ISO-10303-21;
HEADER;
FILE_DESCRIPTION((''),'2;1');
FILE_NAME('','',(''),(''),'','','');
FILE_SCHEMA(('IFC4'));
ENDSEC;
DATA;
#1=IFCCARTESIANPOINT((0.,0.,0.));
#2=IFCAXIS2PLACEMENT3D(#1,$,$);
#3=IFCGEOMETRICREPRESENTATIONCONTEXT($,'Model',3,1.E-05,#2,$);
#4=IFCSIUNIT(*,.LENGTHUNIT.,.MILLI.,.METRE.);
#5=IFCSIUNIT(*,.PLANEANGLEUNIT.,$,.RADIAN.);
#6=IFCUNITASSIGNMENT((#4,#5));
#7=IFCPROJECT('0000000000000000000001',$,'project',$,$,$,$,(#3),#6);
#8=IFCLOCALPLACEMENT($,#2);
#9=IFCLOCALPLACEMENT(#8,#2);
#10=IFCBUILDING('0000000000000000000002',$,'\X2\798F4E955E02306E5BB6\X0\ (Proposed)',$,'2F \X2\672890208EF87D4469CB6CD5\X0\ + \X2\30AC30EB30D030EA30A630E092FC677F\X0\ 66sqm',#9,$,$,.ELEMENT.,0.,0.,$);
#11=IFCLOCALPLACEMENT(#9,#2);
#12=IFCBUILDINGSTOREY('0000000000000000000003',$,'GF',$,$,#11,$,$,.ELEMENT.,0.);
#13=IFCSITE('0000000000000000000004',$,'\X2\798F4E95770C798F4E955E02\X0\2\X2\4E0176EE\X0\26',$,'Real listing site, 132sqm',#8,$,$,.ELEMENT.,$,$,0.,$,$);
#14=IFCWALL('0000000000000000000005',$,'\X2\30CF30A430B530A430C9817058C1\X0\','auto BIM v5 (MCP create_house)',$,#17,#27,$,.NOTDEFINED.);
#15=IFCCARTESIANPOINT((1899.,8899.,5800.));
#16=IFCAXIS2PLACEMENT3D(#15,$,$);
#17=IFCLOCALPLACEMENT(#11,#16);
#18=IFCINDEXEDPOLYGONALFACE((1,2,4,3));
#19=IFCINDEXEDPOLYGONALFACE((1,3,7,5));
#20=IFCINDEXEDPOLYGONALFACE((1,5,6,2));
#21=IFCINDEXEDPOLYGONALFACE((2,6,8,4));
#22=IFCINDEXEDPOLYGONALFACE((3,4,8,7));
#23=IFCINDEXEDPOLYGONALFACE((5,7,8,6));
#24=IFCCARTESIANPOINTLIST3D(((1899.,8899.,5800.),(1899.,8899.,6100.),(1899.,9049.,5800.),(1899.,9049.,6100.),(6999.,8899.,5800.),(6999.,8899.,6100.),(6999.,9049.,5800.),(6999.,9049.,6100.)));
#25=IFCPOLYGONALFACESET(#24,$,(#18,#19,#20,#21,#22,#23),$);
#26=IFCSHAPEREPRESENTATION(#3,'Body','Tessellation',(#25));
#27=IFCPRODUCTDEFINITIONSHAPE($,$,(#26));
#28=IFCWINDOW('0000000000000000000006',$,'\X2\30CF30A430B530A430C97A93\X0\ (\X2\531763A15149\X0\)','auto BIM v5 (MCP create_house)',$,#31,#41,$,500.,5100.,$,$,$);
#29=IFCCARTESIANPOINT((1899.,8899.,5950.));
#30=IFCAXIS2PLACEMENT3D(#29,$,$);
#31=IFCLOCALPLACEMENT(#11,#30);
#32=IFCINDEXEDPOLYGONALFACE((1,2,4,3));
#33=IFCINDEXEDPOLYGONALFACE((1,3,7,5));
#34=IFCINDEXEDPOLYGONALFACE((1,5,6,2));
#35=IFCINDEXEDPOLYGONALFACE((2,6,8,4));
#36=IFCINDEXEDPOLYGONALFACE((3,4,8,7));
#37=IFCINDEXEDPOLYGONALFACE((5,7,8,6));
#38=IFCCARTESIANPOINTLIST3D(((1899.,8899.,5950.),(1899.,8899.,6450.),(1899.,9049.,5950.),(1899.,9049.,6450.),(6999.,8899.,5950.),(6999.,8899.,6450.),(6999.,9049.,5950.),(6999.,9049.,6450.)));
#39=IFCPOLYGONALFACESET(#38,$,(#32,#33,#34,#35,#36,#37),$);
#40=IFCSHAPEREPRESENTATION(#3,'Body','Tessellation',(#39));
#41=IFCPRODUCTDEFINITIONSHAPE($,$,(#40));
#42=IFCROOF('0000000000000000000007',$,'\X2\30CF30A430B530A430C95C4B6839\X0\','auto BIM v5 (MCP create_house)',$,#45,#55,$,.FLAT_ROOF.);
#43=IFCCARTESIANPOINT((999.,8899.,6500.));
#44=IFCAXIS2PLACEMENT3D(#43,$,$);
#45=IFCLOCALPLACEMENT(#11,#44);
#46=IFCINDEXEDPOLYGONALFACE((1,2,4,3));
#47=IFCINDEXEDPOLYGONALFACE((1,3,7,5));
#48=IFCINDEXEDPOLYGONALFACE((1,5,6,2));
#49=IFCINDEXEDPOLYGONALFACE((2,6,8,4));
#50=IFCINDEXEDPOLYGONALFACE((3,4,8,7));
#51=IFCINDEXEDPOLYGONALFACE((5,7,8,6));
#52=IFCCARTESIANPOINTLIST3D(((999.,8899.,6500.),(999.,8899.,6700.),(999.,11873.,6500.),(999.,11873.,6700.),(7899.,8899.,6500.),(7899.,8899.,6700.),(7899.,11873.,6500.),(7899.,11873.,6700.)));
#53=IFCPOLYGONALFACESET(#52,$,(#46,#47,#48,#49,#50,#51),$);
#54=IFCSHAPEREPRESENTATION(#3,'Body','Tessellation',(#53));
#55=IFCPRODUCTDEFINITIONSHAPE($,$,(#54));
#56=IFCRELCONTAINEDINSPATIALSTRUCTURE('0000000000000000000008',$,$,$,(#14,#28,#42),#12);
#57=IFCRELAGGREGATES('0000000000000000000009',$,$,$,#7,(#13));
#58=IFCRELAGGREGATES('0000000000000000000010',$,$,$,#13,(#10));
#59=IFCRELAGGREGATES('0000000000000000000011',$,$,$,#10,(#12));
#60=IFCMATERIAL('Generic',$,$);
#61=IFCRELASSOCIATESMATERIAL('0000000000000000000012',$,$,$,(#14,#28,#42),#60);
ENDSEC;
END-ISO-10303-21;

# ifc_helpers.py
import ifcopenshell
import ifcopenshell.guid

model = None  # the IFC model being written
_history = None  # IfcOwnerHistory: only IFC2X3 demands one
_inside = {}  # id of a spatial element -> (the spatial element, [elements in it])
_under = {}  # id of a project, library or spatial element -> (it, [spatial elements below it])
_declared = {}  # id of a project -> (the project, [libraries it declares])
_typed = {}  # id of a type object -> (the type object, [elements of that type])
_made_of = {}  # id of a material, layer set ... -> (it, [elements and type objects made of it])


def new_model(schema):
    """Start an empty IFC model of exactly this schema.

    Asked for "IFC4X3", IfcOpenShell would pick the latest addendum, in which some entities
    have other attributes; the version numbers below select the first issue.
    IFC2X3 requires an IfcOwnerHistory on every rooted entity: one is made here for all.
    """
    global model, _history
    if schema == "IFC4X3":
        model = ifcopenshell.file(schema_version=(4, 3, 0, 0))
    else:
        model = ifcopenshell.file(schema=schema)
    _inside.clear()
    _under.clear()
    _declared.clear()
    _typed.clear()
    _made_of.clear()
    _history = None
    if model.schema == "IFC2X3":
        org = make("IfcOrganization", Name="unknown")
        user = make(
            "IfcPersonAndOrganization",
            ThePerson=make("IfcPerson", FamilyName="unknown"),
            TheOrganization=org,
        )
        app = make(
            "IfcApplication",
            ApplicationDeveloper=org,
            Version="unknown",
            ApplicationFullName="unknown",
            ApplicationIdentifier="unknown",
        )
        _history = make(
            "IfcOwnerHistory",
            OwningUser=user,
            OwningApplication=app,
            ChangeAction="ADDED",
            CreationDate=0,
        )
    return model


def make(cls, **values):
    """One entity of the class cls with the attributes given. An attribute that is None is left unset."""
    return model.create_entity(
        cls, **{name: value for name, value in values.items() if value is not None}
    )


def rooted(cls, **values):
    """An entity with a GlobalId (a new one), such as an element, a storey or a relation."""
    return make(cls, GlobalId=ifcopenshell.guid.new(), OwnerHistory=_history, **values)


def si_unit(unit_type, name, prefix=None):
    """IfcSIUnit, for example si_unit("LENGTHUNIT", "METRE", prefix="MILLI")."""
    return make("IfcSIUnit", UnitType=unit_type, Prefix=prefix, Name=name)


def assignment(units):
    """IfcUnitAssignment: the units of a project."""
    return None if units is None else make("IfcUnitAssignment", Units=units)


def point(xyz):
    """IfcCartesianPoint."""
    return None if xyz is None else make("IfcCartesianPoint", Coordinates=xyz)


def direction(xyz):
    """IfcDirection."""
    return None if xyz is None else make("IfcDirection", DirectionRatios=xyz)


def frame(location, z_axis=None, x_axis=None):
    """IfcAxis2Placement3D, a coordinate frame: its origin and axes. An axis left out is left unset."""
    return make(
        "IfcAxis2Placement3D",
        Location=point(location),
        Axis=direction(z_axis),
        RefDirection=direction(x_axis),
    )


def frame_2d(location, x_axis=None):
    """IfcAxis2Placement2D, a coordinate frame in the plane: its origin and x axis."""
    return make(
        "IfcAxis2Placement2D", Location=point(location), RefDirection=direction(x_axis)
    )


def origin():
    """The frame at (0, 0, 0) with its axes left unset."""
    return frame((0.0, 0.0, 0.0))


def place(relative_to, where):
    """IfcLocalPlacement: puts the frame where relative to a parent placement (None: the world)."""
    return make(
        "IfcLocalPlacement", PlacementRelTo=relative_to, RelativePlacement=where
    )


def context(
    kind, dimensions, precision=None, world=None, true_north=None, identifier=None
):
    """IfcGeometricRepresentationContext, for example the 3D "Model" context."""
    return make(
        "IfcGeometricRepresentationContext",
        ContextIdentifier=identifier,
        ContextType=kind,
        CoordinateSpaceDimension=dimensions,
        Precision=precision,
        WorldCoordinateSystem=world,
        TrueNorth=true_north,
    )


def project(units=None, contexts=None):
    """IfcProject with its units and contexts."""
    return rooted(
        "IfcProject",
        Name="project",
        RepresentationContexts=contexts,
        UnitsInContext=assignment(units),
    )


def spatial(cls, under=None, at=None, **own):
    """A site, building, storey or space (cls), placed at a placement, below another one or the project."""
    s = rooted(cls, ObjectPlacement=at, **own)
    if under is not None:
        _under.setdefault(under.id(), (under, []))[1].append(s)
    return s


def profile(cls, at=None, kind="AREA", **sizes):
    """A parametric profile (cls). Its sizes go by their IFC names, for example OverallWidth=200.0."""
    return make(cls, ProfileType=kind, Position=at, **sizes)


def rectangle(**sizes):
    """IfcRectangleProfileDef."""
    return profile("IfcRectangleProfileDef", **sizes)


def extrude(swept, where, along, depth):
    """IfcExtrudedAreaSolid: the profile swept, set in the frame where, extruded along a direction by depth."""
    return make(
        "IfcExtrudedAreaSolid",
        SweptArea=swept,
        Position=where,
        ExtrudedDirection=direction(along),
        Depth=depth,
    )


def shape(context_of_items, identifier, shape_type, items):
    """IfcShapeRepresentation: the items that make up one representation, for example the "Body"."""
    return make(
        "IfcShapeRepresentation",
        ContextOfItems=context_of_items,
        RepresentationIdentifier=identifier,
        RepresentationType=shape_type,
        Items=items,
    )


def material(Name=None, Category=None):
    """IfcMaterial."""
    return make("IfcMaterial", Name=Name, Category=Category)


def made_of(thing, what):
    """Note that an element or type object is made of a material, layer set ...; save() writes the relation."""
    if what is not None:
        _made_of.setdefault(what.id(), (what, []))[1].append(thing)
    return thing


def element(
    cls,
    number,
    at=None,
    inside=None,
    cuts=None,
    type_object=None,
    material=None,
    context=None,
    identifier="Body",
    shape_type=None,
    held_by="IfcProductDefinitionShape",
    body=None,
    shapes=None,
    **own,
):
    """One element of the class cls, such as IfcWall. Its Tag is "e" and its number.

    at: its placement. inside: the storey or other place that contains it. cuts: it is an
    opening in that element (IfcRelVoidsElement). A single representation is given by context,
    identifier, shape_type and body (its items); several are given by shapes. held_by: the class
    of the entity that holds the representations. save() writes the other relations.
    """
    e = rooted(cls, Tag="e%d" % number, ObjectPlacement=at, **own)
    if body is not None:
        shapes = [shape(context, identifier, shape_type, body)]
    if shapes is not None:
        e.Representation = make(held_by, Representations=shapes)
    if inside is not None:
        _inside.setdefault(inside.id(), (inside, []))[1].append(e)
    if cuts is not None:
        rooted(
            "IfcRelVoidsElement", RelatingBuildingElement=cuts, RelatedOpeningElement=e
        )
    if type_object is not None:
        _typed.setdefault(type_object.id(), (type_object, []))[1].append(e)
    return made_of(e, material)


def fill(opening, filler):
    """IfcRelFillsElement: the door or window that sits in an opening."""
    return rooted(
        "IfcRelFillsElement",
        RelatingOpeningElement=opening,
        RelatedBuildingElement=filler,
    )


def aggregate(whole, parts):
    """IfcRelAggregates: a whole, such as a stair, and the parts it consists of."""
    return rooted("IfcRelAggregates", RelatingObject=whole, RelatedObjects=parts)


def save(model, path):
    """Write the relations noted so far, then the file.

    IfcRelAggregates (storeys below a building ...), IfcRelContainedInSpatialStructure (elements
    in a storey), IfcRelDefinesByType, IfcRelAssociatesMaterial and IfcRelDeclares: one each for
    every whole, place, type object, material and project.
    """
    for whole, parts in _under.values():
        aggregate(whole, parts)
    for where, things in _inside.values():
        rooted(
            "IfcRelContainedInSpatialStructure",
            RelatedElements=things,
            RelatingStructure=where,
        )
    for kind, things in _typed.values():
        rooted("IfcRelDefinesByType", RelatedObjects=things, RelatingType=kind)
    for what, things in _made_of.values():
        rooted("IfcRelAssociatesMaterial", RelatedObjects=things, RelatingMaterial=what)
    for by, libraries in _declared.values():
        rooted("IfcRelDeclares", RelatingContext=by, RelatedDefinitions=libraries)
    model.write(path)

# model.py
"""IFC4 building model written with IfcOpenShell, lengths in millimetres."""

from ifc_helpers import new_model, si_unit, frame, frame_2d, origin, place, context, project, spatial, rectangle, extrude, material, element, fill, save


model = new_model("IFC4")

# Units and contexts
model_context = context("Model", 3, precision=1e-05, world=origin())
ifc_project = project(units=[si_unit("LENGTHUNIT", "METRE", prefix="MILLI"), si_unit("PLANEANGLEUNIT", "RADIAN")], contexts=[model_context])

# Site, building, storey
site_placement = place(None, origin())
site = spatial("IfcSite", under=ifc_project, at=site_placement, Name="福井県福井市2丁目26", ObjectType="Real listing site, 132sqm", CompositionType="ELEMENT", RefElevation=0.0)
building_placement = place(site_placement, origin())
building = spatial("IfcBuilding", under=site, at=building_placement, Name="福井市の家 (Proposed)", ObjectType="2F 木造軸組構法 + ガルバリウム鋼板 66sqm", CompositionType="ELEMENT", ElevationOfRefHeight=0.0, ElevationOfTerrain=0.0)
storey_placement = place(building_placement, origin())
storey = spatial("IfcBuildingStorey", under=building, at=storey_placement, Name="GF", CompositionType="ELEMENT", Elevation=0.0)

# Shared definitions
ifc_material = material(Name="Generic")

# Wall, opening, window
wall_1_placement = place(storey_placement, frame((1899.0, 8899.0, 5800.0)))
wall_1 = element("IfcWall", 1, at=wall_1_placement, inside=storey, material=ifc_material, Name="ハイサイド腰壁", Description="auto BIM v5 (MCP create_house)", PredefinedType="NOTDEFINED", context=model_context, shape_type="SweptSolid", body=[
    extrude(rectangle(XDim=5100.0, YDim=150.0, at=frame_2d((2550.0, 75.0))), frame((1899.0, 8899.0, 5800.0)), (0.0, 0.0, 1.0), 700.0),
])
opening_1_placement = place(storey_placement, frame((1899.0, 8899.0, 5950.0)))
opening_1 = element("IfcOpeningElement", 2, at=opening_1_placement, cuts=wall_1, PredefinedType="NOTDEFINED", context=model_context, shape_type="SweptSolid", body=[
    extrude(rectangle(XDim=5100.0, YDim=150.0, at=frame_2d((2550.0, 75.0))), frame((1899.0, 8899.0, 5950.0)), (0.0, 0.0, 1.0), 500.0),
])
window_1_placement = place(storey_placement, frame((1899.0, 8899.0, 5950.0)))
window_1 = element("IfcWindow", 3, at=window_1_placement, inside=storey, material=ifc_material, Name="ハイサイド窓 (北採光)", Description="auto BIM v5 (MCP create_house)", OverallHeight=500.0, OverallWidth=5100.0, context=model_context, shape_type="SweptSolid", body=[
    extrude(rectangle(XDim=5100.0, YDim=150.0, at=frame_2d((2550.0, 75.0))), frame((1899.0, 8899.0, 5950.0)), (0.0, 0.0, 1.0), 500.0),
])
fill(opening_1, window_1)

# Roof
roof_placement = place(storey_placement, frame((999.0, 8899.0, 6500.0)))
element("IfcRoof", 4, at=roof_placement, inside=storey, material=ifc_material, Name="ハイサイド屋根", Description="auto BIM v5 (MCP create_house)", PredefinedType="FLAT_ROOF", context=model_context, shape_type="SweptSolid", body=[
    extrude(rectangle(XDim=6900.0, YDim=2974.0, at=frame_2d((3450.0, 1487.0))), frame((999.0, 8899.0, 6500.0)), (0.0, 0.0, 1.0), 200.0),
])

save(model, "model.ifc")
